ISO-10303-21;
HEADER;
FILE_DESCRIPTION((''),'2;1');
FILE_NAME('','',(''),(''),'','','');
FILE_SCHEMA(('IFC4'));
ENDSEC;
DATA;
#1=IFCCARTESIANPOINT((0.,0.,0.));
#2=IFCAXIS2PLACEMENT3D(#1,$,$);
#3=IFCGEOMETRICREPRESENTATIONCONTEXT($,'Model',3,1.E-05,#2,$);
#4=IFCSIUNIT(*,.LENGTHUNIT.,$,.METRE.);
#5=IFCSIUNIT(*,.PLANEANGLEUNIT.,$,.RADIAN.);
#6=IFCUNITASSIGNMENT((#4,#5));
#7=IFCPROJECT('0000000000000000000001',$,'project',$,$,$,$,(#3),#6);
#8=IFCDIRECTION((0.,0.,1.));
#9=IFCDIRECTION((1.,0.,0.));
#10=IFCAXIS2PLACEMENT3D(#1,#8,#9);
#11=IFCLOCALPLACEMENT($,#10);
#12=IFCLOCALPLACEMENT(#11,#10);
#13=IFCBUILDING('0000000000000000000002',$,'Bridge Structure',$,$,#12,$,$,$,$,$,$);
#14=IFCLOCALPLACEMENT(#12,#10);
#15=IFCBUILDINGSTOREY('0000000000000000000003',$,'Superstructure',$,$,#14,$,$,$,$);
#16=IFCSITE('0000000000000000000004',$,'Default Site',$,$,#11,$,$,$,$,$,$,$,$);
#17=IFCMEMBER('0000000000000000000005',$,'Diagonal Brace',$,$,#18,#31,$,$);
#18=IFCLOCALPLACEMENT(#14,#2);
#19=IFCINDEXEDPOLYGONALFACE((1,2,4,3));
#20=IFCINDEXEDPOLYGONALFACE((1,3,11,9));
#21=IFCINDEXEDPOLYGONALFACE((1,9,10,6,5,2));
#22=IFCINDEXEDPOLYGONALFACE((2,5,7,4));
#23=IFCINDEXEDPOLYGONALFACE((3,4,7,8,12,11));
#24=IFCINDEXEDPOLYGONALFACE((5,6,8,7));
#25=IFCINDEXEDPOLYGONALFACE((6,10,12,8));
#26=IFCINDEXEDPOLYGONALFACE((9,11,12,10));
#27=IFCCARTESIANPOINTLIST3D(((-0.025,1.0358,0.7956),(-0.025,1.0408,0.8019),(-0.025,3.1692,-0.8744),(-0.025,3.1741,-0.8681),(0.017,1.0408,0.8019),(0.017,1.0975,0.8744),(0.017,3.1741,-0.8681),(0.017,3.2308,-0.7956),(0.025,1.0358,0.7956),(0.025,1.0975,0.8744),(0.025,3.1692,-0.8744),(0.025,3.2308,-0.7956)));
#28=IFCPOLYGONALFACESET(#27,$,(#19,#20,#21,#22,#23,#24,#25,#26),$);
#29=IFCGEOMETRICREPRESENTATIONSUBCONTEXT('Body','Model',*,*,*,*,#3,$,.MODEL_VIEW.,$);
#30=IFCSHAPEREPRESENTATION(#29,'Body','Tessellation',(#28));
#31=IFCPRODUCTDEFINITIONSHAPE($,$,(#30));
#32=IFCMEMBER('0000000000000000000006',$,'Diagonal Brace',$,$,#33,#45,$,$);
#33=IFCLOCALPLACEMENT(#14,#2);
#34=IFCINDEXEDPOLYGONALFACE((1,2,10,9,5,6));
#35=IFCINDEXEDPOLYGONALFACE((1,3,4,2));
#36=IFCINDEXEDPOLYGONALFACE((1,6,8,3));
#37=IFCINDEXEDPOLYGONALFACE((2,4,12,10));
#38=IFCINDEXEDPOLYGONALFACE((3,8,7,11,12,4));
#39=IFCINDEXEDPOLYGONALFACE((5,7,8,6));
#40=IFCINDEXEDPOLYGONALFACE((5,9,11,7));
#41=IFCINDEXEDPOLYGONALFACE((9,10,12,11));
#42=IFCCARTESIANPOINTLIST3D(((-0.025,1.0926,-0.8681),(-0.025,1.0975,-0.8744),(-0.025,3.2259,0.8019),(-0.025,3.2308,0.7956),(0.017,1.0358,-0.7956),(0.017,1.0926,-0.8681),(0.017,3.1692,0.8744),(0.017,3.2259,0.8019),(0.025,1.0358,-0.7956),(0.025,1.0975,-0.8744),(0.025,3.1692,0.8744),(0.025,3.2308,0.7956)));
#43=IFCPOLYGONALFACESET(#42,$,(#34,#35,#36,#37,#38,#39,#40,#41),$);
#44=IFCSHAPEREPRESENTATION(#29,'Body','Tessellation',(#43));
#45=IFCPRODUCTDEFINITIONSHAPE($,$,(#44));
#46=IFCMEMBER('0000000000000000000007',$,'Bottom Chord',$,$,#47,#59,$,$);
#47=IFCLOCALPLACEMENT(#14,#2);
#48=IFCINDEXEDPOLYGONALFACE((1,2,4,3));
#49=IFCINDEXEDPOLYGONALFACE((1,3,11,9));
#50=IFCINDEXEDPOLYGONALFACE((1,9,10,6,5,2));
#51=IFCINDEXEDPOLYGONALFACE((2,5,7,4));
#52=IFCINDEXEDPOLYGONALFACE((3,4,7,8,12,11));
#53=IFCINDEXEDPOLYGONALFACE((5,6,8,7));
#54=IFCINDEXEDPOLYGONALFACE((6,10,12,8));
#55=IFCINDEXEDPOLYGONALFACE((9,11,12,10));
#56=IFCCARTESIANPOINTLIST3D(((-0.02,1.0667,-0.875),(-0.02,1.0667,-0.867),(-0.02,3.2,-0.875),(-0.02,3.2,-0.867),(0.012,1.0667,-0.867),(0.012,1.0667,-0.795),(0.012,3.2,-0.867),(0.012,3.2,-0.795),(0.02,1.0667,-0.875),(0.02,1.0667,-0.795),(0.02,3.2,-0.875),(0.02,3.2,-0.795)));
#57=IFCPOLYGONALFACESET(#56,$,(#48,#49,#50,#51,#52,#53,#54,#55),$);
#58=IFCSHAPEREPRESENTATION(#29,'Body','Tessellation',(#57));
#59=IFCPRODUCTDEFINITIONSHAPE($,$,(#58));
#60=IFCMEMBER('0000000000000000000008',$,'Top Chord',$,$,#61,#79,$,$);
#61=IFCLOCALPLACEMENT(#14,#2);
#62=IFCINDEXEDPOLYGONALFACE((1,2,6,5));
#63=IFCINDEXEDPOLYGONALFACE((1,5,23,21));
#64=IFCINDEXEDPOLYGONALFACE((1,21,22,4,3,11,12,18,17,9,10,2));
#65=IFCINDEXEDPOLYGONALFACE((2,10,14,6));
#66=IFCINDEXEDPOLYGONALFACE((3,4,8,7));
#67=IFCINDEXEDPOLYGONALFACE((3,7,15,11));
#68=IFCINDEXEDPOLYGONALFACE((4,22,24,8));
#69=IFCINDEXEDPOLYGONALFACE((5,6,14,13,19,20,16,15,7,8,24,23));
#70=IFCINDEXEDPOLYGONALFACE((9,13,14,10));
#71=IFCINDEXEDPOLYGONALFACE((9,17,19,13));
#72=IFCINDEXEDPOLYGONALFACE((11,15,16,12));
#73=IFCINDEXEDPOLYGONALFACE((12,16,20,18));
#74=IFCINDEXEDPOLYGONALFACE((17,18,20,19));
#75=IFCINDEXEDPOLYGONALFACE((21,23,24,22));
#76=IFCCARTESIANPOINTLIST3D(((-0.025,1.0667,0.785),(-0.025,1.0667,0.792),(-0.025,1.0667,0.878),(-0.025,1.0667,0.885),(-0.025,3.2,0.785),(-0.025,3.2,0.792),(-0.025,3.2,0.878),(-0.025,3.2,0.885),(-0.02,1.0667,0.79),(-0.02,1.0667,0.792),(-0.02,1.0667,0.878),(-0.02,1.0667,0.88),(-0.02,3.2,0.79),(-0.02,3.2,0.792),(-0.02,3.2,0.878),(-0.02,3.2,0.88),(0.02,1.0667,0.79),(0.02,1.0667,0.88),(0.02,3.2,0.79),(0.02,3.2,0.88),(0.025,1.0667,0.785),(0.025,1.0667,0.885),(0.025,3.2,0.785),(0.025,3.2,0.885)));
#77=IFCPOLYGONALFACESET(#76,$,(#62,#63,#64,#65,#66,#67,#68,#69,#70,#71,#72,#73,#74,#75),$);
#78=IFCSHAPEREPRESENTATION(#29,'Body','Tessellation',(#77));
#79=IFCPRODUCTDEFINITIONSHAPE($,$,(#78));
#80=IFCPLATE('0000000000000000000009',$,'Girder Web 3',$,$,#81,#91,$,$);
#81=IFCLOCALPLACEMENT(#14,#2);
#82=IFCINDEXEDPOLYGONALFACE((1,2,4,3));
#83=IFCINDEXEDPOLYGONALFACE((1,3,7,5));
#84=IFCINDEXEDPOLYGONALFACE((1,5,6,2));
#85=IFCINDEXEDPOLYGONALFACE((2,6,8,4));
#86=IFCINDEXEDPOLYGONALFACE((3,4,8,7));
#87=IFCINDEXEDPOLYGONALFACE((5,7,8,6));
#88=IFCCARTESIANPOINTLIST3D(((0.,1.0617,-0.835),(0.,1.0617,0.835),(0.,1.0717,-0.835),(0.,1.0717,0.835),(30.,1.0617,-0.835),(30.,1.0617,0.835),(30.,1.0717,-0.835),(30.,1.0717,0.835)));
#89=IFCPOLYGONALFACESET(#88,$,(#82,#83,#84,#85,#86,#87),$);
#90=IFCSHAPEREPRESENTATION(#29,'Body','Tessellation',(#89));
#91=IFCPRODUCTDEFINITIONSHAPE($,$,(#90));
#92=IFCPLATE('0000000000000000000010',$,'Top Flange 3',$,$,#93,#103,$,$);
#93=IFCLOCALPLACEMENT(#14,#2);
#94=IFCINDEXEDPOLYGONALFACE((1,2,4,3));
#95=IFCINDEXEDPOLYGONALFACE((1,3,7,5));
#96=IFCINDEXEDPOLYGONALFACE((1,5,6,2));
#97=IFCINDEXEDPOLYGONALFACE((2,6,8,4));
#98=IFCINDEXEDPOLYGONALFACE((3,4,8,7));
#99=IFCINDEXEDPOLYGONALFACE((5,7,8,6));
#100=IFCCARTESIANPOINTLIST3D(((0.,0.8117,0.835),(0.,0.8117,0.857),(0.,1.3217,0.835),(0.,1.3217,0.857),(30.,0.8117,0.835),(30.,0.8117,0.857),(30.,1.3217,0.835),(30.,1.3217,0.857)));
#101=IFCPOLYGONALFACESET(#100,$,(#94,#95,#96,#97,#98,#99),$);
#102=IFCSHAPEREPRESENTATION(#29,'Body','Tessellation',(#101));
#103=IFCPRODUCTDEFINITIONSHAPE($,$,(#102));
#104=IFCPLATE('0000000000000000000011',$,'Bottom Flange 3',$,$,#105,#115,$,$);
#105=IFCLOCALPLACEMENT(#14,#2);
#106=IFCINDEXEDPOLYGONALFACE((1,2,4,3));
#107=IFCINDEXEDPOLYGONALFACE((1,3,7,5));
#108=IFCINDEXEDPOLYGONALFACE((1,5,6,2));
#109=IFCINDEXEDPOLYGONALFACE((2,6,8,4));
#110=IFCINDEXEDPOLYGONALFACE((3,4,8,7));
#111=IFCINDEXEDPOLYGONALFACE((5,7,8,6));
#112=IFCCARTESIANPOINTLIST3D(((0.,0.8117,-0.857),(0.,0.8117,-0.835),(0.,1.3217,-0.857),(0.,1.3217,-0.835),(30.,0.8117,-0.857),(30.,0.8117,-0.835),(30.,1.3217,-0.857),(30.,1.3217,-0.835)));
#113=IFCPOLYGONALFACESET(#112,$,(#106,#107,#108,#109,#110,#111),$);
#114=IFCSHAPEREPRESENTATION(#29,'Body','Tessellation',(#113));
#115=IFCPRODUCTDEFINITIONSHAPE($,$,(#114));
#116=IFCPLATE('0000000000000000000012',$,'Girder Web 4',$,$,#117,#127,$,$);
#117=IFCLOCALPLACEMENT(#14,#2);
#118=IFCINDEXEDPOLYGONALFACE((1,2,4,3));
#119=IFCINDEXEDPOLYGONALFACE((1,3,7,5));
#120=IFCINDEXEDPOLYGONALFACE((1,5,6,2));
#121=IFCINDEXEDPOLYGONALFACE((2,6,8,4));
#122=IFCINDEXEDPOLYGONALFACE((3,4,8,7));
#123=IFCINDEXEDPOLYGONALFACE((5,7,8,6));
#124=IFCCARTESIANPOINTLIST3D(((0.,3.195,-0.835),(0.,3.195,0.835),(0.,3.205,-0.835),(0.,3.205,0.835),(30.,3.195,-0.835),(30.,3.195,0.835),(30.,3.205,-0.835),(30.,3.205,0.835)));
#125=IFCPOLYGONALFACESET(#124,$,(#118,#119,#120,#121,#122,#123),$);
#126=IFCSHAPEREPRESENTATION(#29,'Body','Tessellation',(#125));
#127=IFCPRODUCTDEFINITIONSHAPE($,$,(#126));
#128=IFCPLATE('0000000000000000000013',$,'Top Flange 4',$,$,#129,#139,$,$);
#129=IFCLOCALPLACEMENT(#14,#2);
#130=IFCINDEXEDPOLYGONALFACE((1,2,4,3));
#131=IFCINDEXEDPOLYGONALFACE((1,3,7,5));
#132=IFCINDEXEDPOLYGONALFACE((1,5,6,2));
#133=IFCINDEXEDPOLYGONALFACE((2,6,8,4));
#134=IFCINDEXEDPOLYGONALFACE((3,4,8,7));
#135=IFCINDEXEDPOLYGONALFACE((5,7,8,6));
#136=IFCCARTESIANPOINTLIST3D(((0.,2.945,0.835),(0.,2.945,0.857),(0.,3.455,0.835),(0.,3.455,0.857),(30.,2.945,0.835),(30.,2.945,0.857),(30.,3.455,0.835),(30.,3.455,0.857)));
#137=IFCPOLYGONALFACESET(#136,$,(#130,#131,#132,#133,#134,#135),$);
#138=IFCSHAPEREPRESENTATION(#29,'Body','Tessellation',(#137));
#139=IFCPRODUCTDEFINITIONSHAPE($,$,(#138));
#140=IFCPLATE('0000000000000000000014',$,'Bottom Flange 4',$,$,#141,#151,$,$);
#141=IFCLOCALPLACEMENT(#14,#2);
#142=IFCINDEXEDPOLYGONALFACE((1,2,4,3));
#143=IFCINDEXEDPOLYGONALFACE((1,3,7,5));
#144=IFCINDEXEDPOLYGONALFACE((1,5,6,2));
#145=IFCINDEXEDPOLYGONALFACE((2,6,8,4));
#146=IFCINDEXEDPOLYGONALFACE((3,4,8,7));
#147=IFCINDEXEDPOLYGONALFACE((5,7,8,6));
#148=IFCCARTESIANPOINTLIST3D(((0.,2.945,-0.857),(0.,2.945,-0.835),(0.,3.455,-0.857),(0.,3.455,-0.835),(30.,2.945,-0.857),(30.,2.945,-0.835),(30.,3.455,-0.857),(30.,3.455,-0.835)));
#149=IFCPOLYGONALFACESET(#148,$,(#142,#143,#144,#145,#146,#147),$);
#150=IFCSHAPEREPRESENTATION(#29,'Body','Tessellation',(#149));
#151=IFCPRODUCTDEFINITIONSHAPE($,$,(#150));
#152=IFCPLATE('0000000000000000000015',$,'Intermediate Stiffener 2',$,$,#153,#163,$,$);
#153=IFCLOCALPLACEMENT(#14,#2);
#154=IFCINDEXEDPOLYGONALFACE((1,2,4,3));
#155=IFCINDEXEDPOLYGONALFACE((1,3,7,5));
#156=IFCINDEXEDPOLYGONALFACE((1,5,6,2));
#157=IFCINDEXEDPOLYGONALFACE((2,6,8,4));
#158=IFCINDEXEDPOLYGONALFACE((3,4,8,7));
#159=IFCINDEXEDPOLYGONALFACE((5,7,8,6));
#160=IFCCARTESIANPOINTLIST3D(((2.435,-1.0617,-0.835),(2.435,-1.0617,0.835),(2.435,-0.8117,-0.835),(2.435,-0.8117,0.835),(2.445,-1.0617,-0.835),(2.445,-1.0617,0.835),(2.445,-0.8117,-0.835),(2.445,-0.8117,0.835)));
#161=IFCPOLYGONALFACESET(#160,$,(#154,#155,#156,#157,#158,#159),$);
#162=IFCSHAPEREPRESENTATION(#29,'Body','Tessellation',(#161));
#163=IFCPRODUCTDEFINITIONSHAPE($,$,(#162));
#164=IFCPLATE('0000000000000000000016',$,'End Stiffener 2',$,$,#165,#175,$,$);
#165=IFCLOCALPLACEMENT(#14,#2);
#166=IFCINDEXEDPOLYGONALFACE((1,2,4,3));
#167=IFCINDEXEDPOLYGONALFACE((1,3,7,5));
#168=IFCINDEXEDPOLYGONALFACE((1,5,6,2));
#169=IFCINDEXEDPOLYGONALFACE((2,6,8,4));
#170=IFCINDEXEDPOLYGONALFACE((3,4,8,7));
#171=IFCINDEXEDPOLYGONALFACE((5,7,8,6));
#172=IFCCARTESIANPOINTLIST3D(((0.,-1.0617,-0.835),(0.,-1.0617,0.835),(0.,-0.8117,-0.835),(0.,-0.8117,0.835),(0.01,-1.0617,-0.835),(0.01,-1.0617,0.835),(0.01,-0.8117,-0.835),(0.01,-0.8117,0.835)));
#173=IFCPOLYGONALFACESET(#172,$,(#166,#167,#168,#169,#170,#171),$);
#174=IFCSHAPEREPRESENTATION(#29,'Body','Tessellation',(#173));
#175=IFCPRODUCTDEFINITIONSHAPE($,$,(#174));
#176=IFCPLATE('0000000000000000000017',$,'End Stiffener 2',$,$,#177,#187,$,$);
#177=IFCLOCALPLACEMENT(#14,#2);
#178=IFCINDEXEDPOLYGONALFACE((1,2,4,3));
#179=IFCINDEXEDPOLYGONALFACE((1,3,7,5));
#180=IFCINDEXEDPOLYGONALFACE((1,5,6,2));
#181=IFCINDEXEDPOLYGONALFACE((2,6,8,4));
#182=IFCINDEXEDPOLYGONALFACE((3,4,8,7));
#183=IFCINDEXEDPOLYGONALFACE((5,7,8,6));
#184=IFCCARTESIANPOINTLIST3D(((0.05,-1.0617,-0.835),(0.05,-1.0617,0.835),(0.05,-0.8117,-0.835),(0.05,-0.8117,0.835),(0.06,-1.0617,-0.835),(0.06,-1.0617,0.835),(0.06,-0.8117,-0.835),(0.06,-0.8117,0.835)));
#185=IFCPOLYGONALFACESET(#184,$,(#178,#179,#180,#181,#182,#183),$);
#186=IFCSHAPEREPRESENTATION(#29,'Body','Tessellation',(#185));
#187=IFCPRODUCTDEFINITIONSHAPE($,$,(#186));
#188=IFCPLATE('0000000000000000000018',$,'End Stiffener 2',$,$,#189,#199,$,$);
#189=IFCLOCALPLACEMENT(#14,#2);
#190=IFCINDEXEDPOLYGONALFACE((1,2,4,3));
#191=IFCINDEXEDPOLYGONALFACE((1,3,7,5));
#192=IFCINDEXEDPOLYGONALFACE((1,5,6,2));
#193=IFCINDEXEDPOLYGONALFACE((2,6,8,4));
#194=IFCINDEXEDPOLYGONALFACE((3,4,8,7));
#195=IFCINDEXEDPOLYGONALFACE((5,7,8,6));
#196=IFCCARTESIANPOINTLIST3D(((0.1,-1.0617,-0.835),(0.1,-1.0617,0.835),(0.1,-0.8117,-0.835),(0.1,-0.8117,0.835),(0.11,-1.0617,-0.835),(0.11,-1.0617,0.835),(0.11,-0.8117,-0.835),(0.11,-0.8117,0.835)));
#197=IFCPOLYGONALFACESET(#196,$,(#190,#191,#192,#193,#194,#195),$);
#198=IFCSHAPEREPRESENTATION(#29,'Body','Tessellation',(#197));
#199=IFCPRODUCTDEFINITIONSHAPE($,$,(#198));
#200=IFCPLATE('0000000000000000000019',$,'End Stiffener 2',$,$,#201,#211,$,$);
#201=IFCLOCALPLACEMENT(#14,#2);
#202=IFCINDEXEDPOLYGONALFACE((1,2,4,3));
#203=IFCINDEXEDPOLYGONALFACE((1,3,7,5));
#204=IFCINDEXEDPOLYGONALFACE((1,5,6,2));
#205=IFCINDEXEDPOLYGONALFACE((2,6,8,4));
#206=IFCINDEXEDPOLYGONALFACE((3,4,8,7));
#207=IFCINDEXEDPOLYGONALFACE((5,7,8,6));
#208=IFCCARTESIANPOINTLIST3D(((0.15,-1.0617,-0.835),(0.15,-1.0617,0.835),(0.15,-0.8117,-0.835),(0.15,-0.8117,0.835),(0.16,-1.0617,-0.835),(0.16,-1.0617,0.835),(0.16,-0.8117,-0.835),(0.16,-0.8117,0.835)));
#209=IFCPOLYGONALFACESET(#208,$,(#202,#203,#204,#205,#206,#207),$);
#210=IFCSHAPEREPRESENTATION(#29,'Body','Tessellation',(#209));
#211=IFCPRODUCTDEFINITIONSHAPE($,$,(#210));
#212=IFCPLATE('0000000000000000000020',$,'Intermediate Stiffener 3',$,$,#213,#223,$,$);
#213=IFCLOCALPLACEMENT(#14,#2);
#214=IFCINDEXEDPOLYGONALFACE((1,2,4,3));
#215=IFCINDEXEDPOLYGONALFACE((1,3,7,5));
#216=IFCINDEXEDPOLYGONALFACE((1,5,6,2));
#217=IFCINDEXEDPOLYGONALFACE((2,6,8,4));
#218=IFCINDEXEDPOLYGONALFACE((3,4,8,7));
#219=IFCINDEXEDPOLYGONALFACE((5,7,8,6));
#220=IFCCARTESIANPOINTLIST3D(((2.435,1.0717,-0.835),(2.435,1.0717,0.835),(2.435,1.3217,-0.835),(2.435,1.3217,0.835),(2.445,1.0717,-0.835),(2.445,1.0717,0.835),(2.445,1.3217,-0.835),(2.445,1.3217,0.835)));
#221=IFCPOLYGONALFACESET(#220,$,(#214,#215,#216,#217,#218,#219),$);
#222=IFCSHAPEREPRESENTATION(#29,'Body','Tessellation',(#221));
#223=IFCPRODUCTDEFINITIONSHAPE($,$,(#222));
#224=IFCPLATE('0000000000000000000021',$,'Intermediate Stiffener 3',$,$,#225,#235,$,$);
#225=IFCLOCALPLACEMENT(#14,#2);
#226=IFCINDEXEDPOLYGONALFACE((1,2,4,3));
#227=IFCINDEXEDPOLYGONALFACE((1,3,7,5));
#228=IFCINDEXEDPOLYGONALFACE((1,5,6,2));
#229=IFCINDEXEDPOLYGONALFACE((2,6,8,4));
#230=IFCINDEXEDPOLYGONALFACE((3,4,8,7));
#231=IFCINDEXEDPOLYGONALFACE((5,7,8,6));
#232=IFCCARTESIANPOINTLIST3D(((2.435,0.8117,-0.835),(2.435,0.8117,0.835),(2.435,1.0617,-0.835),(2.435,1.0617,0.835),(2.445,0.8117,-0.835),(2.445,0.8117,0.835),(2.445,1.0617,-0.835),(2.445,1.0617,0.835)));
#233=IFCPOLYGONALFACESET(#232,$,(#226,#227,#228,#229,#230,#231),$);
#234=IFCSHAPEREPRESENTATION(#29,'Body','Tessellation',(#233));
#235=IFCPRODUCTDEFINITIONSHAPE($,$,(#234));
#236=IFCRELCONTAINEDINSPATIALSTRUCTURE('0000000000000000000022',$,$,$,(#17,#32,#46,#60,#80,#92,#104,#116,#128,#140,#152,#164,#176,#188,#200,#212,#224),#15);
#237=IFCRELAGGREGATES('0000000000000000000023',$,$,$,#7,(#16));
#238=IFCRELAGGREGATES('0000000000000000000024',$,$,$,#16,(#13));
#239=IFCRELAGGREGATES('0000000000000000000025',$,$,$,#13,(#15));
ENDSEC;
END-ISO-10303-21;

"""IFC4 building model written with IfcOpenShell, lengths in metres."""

from ifc_helpers import new_model, si_unit, frame, origin, origin_with_axes, origin_2d_with_axis, place, context, subcontext, project, spatial, rectangle, l_section, c_section, extrude, element, save


model = new_model("IFC4")

# Units and contexts
model_context = context("Model", 3, precision=1e-05, world=origin())
body_context = subcontext(model_context, "Body", "Model", "MODEL_VIEW")
ifc_project = project(units=[si_unit("LENGTHUNIT", "METRE"), si_unit("PLANEANGLEUNIT", "RADIAN")], contexts=[model_context])

# Site, building, storey
site_placement = place(None, origin_with_axes())
site = spatial("IfcSite", under=ifc_project, at=site_placement, Name="Default Site")
building_placement = place(site_placement, origin_with_axes())
building = spatial("IfcBuilding", under=site, at=building_placement, Name="Bridge Structure")
storey_placement = place(building_placement, origin_with_axes())
storey = spatial("IfcBuildingStorey", under=building, at=storey_placement, Name="Superstructure")

# Members
for number, where, z_axis, x_axis, name in (
    (1, (0.0, 1.0667, 0.835), (0.0, 0.787427, -0.616408), (-1.0, 0.0, 0.0), "Diagonal Brace"),
    (2, (0.0, 1.0667, -0.835), (0.0, 0.787427, 0.616408), (-1.0, 0.0, 0.0), "Diagonal Brace"),
):
    element("IfcMember", number, at=place(storey_placement, frame(where, z_axis=z_axis, x_axis=x_axis)), inside=storey, Name=name, context=body_context, shape_type="SweptSolid", body=[
        extrude(l_section(Depth=0.1, Width=0.05, Thickness=0.008, at=origin_2d_with_axis()), origin_with_axes(), (0.0, 0.0, 1.0), 2.7092),
    ])
member_1_placement = place(storey_placement, frame((0.0, 1.0667, -0.835), z_axis=(0.0, 1.0, 0.0), x_axis=(-1.0, 0.0, 0.0)))
element("IfcMember", 3, at=member_1_placement, inside=storey, Name="Bottom Chord", context=body_context, shape_type="SweptSolid", body=[
    extrude(l_section(Depth=0.08, Width=0.04, Thickness=0.008, at=origin_2d_with_axis()), origin_with_axes(), (0.0, 0.0, 1.0), 2.1333),
])
member_2_placement = place(storey_placement, frame((0.0, 1.0667, 0.835), z_axis=(0.0, 1.0, 0.0), x_axis=(-1.0, 0.0, 0.0)))
element("IfcMember", 4, at=member_2_placement, inside=storey, Name="Top Chord", context=body_context, shape_type="SweptSolid", body=[
    extrude(c_section(Depth=0.1, Width=0.05, WallThickness=0.005, Girth=0.007, at=origin_2d_with_axis()), origin_with_axes(), (0.0, 0.0, 1.0), 2.1333),
])

# Plates
plate_1_placement = place(storey_placement, frame((0.0, 1.0667, 0.0), z_axis=(1.0, 0.0, 0.0), x_axis=(0.0, 1.0, 0.0)))
element("IfcPlate", 5, at=plate_1_placement, inside=storey, Name="Girder Web 3", context=body_context, shape_type="SweptSolid", body=[
    extrude(rectangle(XDim=0.01, YDim=1.67, at=origin_2d_with_axis()), origin_with_axes(), (0.0, 0.0, 1.0), 30.0),
])
for number, where, z_axis, x_axis, name in (
    (6, (0.0, 1.0667, 0.846), (1.0, 0.0, 0.0), (0.0, 1.0, 0.0), "Top Flange 3"),
    (7, (0.0, 1.0667, -0.846), (1.0, 0.0, 0.0), (0.0, 1.0, 0.0), "Bottom Flange 3"),
):
    element("IfcPlate", number, at=place(storey_placement, frame(where, z_axis=z_axis, x_axis=x_axis)), inside=storey, Name=name, context=body_context, shape_type="SweptSolid", body=[
        extrude(rectangle(XDim=0.51, YDim=0.022, at=origin_2d_with_axis()), origin_with_axes(), (0.0, 0.0, 1.0), 30.0),
    ])
plate_2_placement = place(storey_placement, frame((0.0, 3.2, 0.0), z_axis=(1.0, 0.0, 0.0), x_axis=(0.0, 1.0, 0.0)))
element("IfcPlate", 8, at=plate_2_placement, inside=storey, Name="Girder Web 4", context=body_context, shape_type="SweptSolid", body=[
    extrude(rectangle(XDim=0.01, YDim=1.67, at=origin_2d_with_axis()), origin_with_axes(), (0.0, 0.0, 1.0), 30.0),
])
for number, where, z_axis, x_axis, name in (
    (9, (0.0, 3.2, 0.846), (1.0, 0.0, 0.0), (0.0, 1.0, 0.0), "Top Flange 4"),
    (10, (0.0, 3.2, -0.846), (1.0, 0.0, 0.0), (0.0, 1.0, 0.0), "Bottom Flange 4"),
):
    element("IfcPlate", number, at=place(storey_placement, frame(where, z_axis=z_axis, x_axis=x_axis)), inside=storey, Name=name, context=body_context, shape_type="SweptSolid", body=[
        extrude(rectangle(XDim=0.51, YDim=0.022, at=origin_2d_with_axis()), origin_with_axes(), (0.0, 0.0, 1.0), 30.0),
    ])
for number, where, z_axis, x_axis, name in (
    (11, (2.44, -0.9367, -0.835), (0.0, 0.0, 1.0), (1.0, 0.0, 0.0), "Intermediate Stiffener 2"),
    (12, (0.005, -0.9367, -0.835), (0.0, 0.0, 1.0), (1.0, 0.0, 0.0), "End Stiffener 2"),
    (13, (0.055, -0.9367, -0.835), (0.0, 0.0, 1.0), (1.0, 0.0, 0.0), "End Stiffener 2"),
    (14, (0.105, -0.9367, -0.835), (0.0, 0.0, 1.0), (1.0, 0.0, 0.0), "End Stiffener 2"),
    (15, (0.155, -0.9367, -0.835), (0.0, 0.0, 1.0), (1.0, 0.0, 0.0), "End Stiffener 2"),
    (16, (2.44, 1.1967, -0.835), (0.0, 0.0, 1.0), (1.0, 0.0, 0.0), "Intermediate Stiffener 3"),
    (17, (2.44, 0.9367, -0.835), (0.0, 0.0, 1.0), (1.0, 0.0, 0.0), "Intermediate Stiffener 3"),
):
    element("IfcPlate", number, at=place(storey_placement, frame(where, z_axis=z_axis, x_axis=x_axis)), inside=storey, Name=name, context=body_context, shape_type="SweptSolid", body=[
        extrude(rectangle(XDim=0.01, YDim=0.25, at=origin_2d_with_axis()), origin_with_axes(), (0.0, 0.0, 1.0), 1.67),
    ])

save(model, "model.ifc")
